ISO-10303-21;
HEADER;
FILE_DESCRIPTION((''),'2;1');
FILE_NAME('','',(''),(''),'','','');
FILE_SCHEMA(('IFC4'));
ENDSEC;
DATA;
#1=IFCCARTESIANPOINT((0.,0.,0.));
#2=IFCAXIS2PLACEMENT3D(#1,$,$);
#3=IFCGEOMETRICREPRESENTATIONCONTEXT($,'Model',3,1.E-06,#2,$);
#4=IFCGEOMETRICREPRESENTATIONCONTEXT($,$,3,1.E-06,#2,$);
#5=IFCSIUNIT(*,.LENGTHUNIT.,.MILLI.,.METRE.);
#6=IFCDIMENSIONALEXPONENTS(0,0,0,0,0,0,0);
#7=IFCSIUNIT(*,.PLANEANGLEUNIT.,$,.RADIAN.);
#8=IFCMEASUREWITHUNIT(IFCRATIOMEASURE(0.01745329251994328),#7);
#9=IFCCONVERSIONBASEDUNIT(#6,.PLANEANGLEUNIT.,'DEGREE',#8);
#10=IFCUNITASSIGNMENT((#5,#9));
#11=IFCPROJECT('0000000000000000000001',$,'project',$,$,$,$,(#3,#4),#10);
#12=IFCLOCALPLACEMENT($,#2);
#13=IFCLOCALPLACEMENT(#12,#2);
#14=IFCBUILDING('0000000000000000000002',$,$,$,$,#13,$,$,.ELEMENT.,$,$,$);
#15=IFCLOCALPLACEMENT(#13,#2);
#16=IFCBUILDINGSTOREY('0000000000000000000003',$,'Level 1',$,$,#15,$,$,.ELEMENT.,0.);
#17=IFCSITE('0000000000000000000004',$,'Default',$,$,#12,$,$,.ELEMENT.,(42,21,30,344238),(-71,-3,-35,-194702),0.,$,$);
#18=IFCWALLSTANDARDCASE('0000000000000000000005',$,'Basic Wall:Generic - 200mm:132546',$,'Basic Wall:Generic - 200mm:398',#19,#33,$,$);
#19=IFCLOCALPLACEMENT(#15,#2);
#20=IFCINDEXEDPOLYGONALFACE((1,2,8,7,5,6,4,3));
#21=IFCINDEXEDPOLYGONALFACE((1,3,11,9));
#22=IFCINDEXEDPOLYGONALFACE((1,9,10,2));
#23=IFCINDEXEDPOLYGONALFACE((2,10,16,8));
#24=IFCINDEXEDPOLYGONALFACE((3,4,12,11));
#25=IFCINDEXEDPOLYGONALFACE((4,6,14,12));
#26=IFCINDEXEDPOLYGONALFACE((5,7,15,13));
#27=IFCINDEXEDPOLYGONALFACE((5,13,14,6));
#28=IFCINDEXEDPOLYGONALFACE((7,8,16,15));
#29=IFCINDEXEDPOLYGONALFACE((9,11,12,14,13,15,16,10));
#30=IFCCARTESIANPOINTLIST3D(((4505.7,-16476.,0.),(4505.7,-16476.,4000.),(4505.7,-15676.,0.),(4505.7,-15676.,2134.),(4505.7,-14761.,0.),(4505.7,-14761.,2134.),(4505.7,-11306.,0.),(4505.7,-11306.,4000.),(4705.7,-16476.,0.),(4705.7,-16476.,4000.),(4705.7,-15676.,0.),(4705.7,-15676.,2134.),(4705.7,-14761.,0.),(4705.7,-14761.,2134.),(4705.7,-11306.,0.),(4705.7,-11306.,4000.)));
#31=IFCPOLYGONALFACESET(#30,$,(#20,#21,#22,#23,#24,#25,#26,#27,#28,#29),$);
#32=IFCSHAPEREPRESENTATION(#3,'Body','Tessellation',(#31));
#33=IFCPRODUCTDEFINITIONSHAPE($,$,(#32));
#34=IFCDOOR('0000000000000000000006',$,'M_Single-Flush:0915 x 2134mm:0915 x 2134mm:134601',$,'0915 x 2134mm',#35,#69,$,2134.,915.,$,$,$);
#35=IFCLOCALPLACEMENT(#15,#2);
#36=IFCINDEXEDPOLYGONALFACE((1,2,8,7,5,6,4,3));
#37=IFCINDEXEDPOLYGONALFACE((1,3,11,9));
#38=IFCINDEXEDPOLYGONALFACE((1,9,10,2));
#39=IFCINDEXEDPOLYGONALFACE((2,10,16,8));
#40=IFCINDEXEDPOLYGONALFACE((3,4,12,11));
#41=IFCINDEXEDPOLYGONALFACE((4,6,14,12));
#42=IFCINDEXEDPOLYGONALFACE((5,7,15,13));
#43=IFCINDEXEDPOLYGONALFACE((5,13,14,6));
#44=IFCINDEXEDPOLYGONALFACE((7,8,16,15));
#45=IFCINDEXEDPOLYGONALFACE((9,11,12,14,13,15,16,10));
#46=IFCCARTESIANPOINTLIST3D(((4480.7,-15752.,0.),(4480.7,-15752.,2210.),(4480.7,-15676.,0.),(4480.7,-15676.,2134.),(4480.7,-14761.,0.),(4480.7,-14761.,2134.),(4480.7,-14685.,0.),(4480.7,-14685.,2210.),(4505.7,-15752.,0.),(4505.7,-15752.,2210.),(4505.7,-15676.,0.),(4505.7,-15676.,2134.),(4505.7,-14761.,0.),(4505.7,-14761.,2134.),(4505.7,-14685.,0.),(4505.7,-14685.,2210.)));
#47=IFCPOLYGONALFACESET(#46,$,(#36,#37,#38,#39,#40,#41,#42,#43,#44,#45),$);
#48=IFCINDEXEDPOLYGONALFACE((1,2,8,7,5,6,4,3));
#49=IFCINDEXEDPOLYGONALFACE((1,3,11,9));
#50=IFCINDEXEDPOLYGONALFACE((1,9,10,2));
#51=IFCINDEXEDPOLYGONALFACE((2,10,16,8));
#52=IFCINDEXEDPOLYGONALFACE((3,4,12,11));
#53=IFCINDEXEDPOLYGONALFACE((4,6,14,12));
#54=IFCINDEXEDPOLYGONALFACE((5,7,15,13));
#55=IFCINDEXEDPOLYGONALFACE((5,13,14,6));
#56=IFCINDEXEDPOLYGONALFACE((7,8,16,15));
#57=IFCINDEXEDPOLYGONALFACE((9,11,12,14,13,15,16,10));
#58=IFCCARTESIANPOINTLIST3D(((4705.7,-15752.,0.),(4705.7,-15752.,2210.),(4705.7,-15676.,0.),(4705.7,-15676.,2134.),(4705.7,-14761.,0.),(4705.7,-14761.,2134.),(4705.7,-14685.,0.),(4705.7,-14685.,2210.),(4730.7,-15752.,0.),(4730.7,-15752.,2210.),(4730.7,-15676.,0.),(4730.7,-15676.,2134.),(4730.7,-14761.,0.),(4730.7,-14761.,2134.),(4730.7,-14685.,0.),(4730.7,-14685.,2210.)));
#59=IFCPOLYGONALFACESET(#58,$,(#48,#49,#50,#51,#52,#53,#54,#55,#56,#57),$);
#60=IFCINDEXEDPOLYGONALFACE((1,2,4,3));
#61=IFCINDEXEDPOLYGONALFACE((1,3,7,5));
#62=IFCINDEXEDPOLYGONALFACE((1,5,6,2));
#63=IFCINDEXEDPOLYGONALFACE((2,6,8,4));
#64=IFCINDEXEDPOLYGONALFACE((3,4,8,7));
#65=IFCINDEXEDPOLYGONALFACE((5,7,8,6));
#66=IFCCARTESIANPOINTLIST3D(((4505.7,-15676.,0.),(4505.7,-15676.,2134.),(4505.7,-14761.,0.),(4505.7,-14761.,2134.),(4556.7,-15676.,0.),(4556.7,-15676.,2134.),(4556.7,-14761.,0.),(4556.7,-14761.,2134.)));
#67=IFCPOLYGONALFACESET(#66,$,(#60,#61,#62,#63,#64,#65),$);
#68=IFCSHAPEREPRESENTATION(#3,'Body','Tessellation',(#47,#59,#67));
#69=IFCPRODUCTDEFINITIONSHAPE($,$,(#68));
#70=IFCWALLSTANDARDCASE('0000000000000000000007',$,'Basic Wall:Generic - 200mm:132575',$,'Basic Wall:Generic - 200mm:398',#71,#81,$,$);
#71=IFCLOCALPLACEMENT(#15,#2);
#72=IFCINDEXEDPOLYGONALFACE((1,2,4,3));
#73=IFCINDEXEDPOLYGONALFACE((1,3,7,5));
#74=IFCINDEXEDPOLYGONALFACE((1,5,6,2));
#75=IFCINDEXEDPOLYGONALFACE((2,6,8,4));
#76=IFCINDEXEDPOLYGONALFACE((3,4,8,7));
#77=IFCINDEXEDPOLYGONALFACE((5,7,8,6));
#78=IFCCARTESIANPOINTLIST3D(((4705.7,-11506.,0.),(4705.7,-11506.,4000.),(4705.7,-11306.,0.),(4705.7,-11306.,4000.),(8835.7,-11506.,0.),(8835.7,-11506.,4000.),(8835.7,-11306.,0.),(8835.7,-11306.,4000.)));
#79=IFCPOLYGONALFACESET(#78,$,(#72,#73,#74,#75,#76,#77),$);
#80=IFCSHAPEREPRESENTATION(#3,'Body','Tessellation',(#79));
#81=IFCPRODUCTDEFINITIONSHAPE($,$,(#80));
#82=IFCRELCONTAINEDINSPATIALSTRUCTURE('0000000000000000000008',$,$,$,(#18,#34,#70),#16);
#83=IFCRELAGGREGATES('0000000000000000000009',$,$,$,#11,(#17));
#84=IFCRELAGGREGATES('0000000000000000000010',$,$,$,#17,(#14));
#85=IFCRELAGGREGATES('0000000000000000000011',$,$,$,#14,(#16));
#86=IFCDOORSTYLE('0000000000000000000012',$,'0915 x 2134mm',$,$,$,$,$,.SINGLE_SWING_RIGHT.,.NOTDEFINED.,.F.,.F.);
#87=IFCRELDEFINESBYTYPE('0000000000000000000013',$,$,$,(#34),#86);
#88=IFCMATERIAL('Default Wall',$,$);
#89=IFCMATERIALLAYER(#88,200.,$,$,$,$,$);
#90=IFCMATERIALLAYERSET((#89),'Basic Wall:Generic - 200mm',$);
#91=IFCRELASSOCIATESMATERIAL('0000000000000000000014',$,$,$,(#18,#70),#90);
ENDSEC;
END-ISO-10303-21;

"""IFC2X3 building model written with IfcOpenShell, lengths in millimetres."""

from ifc_helpers import new_model, entity, si_unit, converted_unit, frame, frame_2d, origin, origin_2d_with_axis, place, context, project, spatial, polyline, rectangle, outline, extrude, source, transform, mapped, material, layer, layer_set, layer_usage, type_object, type_shapes, element, fill, save


model = new_model("IFC2X3")

# Units and contexts
model_context = context("Model", 3, precision=1e-06, world=origin())
context_of_model = context(None, 3, precision=1e-06, world=origin())
ifc_project = project(units=[si_unit("LENGTHUNIT", "METRE", prefix="MILLI"), converted_unit("PLANEANGLEUNIT", "DEGREE", entity("IfcRatioMeasure", 0.01745329251994328), si_unit("PLANEANGLEUNIT", "RADIAN"), dimensions=[0, 0, 0, 0, 0, 0, 0])], contexts=[model_context, context_of_model])

# Site, building, storey
site_placement = place(None, origin())
site = spatial("IfcSite", under=ifc_project, at=site_placement, Name="Default", CompositionType="ELEMENT", RefLatitude=(42, 21, 30, 344238), RefLongitude=(-71, -3, -35, -194702), RefElevation=0.0)
building_placement = place(site_placement, origin())
building = spatial("IfcBuilding", under=site, at=building_placement, CompositionType="ELEMENT")
storey_placement = place(building_placement, origin())
storey = spatial("IfcBuildingStorey", under=building, at=storey_placement, Name="Level 1", CompositionType="ELEMENT", Elevation=0.0)

# Shared definitions
ifc_material_1 = material(Name="Default Wall")
ifc_layer_1 = layer(ifc_material_1, 200.0)
ifc_layer_set_1 = layer_set([ifc_layer_1], Name="Basic Wall:Generic - 200mm")
door_style_1 = type_object("IfcDoorStyle", Name="0915 x 2134mm", ConstructionType="NOTDEFINED", OperationType="SINGLE_SWING_RIGHT", ParameterTakesPrecedence=False, Sizeable=False)
shared_shape_1 = source(origin(), model_context, "Body", "SweptSolid", [
    extrude(outline(polyline([(-533.5, -1124.0), (533.5, -1124.0), (533.5, 1086.0), (457.5, 1086.0), (457.5, -1048.0), (-457.5, -1048.0), (-457.5, 1086.0), (-533.5, 1086.0), (-533.5, -1124.0)])), frame((457.5, 200.0, 1086.0), z_axis=(0.0, 1.0, 0.0), x_axis=(1.0, 0.0, 0.0)), (0.0, 0.0, 1.0), 25.0),
    extrude(outline(polyline([(-1124.0, -533.5), (1086.0, -533.5), (1086.0, -457.5), (-1048.0, -457.5), (-1048.0, 457.5), (1086.0, 457.5), (1086.0, 533.5), (-1124.0, 533.5), (-1124.0, -533.5)])), frame((457.5, -25.0, 1086.0), z_axis=(0.0, 1.0, 0.0), x_axis=(0.0, 0.0, -1.0)), (0.0, 0.0, 1.0), 25.0),
    extrude(rectangle(XDim=51.0, YDim=915.0, at=origin_2d_with_axis()), frame((457.5, 174.5, 0.0), z_axis=(0.0, 0.0, 1.0), x_axis=(0.0, 1.0, 0.0)), (0.0, 0.0, 1.0), 2134.0),
])
type_shapes(door_style_1, [shared_shape_1])

# Wall, opening, door
ifc_layer_usage_1 = layer_usage(ifc_layer_set_1, "AXIS2", "NEGATIVE", 100.0)
wall_1_placement = place(storey_placement, frame((4605.7, -16476.0, 0.0), z_axis=(0.0, 0.0, 1.0), x_axis=(0.0, 1.0, 0.0)))
wall_1 = element("IfcWallStandardCase", 1, at=wall_1_placement, inside=storey, material=ifc_layer_usage_1, Name="Basic Wall:Generic - 200mm:132546", ObjectType="Basic Wall:Generic - 200mm:398", context=model_context, shape_type="SweptSolid", body=[
    extrude(rectangle(XDim=5170.0, YDim=200.0, at=frame_2d((2585.0, 0.0), x_axis=(-1.0, 0.0))), origin(), (0.0, 0.0, 1.0), 4000.0),
])
opening_1_placement = place(wall_1_placement, frame((800.0, -100.0, 0.0)))
opening_1 = element("IfcOpeningElement", 2, at=opening_1_placement, cuts=wall_1, ObjectType="Opening", context=model_context, shape_type="SweptSolid", body=[
    extrude(rectangle(XDim=915.0, YDim=2134.0, at=frame_2d((1067.0, 457.5), x_axis=(0.0, 1.0))), frame((0.0, 0.0, 0.0), z_axis=(0.0, 1.0, 0.0), x_axis=(0.0, 0.0, 1.0)), (0.0, 0.0, 1.0), 200.0),
])
door_1_placement = place(opening_1_placement, origin())
door_1 = element("IfcDoor", 3, at=door_1_placement, inside=storey, type_object=door_style_1, Name="M_Single-Flush:0915 x 2134mm:0915 x 2134mm:134601", ObjectType="0915 x 2134mm", OverallHeight=2134.0, OverallWidth=915.0, context=model_context, shape_type="MappedRepresentation", body=[
    mapped(shared_shape_1, transform((0.0, 0.0, 0.0), scale=1.0)),
])
fill(opening_1, door_1)

# Wall
ifc_layer_usage_2 = layer_usage(ifc_layer_set_1, "AXIS2", "NEGATIVE", 100.0)
wall_2_placement = place(storey_placement, frame((4705.7, -11406.0, 0.0)))
element("IfcWallStandardCase", 4, at=wall_2_placement, inside=storey, material=ifc_layer_usage_2, Name="Basic Wall:Generic - 200mm:132575", ObjectType="Basic Wall:Generic - 200mm:398", context=model_context, shape_type="SweptSolid", body=[
    extrude(rectangle(XDim=4130.0, YDim=200.0, at=frame_2d((2065.0, 0.0), x_axis=(-1.0, 0.0))), origin(), (0.0, 0.0, 1.0), 4000.0),
])

save(model, "model.ifc")
